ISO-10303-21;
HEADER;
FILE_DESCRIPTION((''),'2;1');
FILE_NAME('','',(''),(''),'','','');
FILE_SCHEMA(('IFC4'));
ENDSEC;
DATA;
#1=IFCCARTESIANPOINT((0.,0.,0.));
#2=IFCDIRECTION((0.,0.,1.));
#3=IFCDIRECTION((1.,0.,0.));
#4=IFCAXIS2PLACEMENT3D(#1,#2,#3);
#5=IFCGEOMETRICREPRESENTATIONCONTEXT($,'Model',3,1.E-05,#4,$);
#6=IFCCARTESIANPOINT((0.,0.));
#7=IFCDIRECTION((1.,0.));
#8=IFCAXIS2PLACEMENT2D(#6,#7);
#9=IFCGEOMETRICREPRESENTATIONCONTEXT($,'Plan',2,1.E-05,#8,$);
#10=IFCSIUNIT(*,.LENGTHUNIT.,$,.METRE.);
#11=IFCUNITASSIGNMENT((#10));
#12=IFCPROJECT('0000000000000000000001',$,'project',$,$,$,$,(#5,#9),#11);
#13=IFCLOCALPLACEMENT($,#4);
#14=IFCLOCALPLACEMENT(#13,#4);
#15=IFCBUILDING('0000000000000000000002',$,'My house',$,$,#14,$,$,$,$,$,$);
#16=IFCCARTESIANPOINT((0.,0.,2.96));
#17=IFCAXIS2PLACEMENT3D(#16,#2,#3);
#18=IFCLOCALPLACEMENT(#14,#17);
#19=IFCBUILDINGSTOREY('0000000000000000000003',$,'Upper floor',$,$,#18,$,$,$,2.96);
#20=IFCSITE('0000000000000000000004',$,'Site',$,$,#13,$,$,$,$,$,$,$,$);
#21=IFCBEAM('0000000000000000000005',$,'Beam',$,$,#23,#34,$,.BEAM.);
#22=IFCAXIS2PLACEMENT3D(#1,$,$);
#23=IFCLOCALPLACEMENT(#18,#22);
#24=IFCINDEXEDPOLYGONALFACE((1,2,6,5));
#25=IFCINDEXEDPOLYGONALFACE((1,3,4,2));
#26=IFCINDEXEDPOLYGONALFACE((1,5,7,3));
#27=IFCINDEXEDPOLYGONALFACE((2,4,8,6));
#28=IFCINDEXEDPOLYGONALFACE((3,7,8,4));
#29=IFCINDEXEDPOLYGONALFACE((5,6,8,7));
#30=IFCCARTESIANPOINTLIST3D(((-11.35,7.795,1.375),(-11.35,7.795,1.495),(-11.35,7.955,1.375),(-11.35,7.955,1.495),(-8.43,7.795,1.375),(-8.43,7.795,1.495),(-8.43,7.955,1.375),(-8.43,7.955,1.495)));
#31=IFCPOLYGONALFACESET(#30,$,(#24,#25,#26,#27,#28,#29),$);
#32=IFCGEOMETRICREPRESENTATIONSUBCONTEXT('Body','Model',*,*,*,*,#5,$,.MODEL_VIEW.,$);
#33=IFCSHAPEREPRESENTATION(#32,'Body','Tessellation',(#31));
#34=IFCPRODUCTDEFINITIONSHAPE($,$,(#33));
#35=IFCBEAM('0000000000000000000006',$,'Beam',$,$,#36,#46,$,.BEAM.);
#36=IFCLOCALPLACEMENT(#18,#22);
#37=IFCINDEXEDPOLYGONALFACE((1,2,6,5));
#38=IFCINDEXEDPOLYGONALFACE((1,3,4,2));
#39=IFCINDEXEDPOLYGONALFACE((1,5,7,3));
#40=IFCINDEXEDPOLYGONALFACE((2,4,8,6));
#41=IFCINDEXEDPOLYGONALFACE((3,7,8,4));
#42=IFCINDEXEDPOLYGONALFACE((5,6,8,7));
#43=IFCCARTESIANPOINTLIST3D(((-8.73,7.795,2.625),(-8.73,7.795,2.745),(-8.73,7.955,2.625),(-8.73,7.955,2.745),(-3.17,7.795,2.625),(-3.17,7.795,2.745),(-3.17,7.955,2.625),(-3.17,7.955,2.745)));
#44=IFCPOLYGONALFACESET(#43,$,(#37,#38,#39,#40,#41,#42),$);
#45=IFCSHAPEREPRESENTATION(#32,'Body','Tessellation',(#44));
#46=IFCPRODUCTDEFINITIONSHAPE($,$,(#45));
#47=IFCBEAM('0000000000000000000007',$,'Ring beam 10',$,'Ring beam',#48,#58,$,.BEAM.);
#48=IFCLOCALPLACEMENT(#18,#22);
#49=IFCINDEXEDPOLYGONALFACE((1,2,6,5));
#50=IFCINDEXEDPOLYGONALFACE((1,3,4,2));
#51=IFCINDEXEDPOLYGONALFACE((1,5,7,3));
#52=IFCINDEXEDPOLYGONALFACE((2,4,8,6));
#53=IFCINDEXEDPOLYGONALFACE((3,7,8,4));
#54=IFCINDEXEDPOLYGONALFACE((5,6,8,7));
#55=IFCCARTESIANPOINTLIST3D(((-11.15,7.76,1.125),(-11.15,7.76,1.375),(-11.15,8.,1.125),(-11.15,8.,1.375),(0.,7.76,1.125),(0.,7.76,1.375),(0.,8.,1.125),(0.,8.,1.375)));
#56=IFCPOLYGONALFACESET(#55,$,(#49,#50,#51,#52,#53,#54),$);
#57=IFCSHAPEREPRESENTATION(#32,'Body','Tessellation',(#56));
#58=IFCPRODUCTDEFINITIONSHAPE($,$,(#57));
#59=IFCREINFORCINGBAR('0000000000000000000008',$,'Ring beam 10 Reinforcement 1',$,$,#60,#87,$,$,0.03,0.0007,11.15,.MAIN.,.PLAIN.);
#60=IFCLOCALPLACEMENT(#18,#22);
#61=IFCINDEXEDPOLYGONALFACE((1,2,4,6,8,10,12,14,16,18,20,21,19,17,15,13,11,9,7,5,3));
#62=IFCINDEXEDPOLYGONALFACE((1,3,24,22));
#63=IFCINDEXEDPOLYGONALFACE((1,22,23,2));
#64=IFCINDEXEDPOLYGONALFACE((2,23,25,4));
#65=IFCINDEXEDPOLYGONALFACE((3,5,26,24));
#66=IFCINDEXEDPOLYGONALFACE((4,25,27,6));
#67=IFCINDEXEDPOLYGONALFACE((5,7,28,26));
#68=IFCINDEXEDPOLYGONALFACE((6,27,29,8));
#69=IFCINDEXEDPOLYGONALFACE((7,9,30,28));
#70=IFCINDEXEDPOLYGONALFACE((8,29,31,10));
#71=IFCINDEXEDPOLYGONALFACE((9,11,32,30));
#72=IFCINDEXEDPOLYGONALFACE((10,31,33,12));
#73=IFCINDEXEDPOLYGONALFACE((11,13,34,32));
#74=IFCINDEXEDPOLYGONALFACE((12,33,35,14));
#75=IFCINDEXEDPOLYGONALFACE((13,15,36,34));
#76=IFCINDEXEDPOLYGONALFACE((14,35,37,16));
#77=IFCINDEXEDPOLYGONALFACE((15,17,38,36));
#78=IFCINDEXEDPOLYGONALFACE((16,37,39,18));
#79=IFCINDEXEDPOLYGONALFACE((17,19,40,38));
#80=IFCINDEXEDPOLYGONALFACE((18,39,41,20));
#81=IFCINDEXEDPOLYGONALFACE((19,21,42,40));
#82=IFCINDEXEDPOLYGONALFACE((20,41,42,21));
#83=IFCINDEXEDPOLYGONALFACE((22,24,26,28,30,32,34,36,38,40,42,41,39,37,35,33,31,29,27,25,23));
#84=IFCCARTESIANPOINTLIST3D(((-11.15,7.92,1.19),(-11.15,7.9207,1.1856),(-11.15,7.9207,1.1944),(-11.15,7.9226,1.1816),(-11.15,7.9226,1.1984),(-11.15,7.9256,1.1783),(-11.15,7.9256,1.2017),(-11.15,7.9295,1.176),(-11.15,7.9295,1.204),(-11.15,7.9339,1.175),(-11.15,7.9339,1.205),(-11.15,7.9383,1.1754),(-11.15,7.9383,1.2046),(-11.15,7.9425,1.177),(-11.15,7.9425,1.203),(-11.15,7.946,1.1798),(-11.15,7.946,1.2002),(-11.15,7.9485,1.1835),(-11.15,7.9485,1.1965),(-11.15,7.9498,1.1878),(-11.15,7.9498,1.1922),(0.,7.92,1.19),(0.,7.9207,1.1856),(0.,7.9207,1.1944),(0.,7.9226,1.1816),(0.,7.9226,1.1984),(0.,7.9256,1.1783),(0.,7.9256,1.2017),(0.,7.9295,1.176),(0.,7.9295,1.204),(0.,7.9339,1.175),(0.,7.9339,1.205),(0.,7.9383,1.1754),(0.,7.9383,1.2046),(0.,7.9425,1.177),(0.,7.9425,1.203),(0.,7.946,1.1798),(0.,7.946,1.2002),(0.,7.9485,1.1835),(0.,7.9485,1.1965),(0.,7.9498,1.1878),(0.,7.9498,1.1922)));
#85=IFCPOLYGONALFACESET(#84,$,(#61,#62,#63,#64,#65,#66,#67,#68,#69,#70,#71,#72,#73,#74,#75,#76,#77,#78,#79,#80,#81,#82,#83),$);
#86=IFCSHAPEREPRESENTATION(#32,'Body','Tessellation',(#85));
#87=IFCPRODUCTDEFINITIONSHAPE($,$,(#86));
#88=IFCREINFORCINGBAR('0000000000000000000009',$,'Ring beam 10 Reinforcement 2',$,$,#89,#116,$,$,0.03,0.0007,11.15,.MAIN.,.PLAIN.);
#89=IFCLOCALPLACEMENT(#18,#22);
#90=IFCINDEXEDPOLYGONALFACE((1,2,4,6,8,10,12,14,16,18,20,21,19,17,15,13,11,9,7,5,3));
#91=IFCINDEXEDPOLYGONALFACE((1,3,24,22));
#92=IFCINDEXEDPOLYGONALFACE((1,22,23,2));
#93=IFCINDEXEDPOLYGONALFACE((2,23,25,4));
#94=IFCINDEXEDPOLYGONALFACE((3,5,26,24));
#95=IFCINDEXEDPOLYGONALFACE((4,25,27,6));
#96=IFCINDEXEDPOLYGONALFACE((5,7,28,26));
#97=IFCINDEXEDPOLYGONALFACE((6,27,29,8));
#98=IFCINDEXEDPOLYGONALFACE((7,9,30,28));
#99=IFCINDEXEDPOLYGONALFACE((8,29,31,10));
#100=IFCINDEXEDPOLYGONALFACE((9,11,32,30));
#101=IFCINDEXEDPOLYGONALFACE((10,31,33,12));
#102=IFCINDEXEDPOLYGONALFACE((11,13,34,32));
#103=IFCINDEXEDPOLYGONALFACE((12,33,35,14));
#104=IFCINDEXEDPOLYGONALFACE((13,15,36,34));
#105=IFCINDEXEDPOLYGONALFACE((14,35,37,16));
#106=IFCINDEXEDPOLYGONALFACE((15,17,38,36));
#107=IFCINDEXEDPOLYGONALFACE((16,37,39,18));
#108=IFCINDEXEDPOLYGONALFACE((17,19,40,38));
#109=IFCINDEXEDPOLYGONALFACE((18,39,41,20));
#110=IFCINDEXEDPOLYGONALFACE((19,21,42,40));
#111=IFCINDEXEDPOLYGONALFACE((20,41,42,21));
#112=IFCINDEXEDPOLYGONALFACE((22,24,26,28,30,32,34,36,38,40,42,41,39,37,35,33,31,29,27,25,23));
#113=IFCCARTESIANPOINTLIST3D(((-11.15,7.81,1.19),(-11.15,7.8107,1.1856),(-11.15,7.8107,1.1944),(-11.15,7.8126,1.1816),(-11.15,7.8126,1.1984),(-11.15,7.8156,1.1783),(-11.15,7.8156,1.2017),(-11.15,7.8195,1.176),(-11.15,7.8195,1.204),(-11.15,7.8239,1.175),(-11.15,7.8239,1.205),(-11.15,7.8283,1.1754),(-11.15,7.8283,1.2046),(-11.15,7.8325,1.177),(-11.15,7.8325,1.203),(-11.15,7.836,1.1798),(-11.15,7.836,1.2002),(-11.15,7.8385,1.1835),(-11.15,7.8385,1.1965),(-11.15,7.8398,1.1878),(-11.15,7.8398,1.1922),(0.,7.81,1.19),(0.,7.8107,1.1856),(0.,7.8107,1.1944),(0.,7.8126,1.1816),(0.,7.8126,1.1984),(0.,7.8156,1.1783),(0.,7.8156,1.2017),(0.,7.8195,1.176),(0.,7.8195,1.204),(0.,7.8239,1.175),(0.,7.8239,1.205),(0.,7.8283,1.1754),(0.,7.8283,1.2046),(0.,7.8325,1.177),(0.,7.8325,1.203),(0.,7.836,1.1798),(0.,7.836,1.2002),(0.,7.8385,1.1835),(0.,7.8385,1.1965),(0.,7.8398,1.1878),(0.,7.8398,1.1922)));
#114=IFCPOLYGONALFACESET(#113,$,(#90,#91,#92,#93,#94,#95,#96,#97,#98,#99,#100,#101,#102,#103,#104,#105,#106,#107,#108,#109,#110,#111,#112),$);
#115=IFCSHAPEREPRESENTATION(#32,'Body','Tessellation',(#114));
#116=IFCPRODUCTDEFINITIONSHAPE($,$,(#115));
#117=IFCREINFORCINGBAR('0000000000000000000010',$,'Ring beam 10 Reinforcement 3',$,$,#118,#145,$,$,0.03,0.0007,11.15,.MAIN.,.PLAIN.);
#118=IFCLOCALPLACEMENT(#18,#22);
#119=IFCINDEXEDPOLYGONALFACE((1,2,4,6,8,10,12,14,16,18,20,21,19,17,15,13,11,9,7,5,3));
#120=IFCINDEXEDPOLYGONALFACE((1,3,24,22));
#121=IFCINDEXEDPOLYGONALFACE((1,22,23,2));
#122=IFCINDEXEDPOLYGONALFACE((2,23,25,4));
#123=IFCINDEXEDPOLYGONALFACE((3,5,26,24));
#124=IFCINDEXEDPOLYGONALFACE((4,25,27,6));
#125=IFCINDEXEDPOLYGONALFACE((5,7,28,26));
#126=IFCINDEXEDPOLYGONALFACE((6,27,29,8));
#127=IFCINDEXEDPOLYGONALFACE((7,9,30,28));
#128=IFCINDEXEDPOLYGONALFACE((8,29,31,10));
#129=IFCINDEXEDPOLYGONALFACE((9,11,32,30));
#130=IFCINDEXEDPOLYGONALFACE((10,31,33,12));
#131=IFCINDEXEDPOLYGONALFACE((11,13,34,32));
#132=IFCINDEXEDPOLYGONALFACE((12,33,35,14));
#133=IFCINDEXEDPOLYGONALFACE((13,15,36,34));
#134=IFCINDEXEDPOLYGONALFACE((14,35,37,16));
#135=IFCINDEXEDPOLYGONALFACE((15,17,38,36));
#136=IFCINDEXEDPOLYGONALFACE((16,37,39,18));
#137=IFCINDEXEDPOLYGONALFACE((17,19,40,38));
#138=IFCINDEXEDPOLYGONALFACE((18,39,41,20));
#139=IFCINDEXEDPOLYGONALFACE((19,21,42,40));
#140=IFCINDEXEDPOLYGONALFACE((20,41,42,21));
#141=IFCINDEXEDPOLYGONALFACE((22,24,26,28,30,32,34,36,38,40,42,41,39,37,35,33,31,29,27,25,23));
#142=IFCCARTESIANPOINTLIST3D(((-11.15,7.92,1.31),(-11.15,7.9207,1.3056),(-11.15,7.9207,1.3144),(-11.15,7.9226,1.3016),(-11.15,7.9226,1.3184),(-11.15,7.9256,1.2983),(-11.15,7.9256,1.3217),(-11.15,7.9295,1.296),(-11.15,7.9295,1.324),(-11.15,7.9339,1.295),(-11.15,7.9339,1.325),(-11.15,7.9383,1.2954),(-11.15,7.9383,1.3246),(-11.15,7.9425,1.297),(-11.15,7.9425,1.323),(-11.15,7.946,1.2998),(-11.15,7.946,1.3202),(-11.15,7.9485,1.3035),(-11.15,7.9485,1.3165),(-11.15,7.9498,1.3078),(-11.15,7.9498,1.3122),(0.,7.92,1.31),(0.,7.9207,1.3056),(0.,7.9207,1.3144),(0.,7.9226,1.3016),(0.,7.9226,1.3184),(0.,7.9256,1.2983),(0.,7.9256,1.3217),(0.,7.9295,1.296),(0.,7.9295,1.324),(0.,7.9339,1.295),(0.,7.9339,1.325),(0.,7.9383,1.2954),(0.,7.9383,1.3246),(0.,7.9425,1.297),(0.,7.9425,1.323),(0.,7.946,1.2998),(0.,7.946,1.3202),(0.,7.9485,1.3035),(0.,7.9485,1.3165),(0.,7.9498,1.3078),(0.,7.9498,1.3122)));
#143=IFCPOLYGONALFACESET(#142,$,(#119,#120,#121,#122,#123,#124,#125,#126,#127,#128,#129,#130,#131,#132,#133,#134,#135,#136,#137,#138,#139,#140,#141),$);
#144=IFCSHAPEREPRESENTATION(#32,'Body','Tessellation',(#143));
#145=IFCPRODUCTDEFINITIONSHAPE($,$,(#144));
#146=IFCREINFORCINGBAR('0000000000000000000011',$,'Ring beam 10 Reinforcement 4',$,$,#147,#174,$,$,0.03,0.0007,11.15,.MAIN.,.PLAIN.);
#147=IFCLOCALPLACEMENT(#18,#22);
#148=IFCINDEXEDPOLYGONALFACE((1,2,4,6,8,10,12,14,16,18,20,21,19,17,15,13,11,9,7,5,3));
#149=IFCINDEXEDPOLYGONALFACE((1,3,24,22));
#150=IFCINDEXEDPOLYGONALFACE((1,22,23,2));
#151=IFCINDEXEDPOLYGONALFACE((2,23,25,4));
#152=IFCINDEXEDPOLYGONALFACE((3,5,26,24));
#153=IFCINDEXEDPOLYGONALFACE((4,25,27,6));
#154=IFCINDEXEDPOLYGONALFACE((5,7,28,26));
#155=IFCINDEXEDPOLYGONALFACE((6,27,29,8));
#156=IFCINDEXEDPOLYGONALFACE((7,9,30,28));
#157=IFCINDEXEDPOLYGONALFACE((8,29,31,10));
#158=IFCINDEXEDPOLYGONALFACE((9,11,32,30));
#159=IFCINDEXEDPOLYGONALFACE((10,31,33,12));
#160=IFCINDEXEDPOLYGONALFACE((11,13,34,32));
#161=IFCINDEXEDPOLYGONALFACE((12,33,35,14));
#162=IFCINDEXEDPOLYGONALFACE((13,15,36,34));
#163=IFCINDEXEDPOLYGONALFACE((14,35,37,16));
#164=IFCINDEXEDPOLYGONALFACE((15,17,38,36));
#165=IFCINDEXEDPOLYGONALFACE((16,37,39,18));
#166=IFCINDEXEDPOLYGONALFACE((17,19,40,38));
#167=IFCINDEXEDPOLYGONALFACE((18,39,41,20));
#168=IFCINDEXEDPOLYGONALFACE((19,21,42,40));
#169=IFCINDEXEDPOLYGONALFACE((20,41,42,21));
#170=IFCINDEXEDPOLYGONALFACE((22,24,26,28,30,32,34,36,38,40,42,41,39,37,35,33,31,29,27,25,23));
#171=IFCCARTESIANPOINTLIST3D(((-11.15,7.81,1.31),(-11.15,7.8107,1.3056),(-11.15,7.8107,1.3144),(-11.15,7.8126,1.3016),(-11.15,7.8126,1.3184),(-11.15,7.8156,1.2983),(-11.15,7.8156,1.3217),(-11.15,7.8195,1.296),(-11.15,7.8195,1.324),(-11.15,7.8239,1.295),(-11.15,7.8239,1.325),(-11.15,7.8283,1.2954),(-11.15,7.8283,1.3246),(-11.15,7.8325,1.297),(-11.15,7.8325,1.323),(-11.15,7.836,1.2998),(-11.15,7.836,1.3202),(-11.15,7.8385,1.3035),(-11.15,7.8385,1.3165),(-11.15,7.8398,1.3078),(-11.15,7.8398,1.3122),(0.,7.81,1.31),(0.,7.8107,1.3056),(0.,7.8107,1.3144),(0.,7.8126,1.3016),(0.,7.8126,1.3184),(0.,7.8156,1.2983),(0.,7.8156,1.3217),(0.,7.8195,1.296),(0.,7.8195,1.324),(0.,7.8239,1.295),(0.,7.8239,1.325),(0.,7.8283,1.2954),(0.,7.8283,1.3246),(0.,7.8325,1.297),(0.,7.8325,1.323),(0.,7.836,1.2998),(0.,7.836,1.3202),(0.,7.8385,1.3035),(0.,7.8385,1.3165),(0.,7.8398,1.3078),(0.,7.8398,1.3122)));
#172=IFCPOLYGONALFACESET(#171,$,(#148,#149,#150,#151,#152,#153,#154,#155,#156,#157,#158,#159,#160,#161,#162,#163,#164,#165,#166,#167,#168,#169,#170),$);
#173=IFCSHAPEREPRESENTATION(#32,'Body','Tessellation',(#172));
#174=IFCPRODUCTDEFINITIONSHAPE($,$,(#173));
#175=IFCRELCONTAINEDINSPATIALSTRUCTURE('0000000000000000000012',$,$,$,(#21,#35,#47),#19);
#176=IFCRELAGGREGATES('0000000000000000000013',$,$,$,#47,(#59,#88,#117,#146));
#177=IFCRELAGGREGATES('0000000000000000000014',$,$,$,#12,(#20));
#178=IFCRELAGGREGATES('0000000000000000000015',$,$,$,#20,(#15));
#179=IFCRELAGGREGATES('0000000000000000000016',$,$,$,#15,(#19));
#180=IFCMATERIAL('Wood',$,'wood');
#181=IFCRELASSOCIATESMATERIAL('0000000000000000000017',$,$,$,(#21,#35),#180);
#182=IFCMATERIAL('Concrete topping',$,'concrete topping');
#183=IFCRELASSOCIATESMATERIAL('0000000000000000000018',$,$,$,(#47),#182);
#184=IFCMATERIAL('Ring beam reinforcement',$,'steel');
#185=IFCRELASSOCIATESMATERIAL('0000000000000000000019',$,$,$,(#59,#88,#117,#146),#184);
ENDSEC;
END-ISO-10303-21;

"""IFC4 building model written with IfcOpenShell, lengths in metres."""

from ifc_helpers import new_model, si_unit, frame, origin_with_axes, origin_2d, origin_2d_with_axis, place, context, subcontext, project, spatial, circle_curve, rectangle, outline, extrude, source, transform, mapped, material, element, aggregate, save


model = new_model("IFC4")

# Units and contexts
model_context = context("Model", 3, precision=1e-05, world=origin_with_axes())
plan_context = context("Plan", 2, precision=1e-05, world=origin_2d_with_axis())
body_context_1 = subcontext(model_context, "Body", "Model", "MODEL_VIEW")
ifc_project = project(units=[si_unit("LENGTHUNIT", "METRE")], contexts=[model_context, plan_context])

# Site, building, storey
site_placement = place(None, origin_with_axes())
site = spatial("IfcSite", under=ifc_project, at=site_placement, Name="Site")
building_placement = place(site_placement, origin_with_axes())
building = spatial("IfcBuilding", under=site, at=building_placement, Name="My house")
storey_placement = place(building_placement, frame((0.0, 0.0, 2.96), z_axis=(0.0, 0.0, 1.0), x_axis=(1.0, 0.0, 0.0)))
storey = spatial("IfcBuildingStorey", under=building, at=storey_placement, Name="Upper floor", Elevation=2.96)

# Shared definitions
ifc_material_1 = material(Name="Concrete topping", Category="concrete topping")

# Beams
ifc_material_2 = material(Name="Wood", Category="wood")
shared_shape_1 = source(origin_with_axes(), body_context_1, "Body", "SweptSolid", [
    extrude(rectangle(XDim=0.16, YDim=0.12), frame((0.0, 0.0, 0.0), z_axis=(1.0, 0.0, 0.0), x_axis=(0.0, 1.0, 0.0)), (0.0, 0.0, 1.0), 2.92),
])
beam_1_placement = place(storey_placement, frame((-8.43, 7.875, 1.435), z_axis=(0.0, 0.0, 1.0), x_axis=(1.0, 0.0, 0.0)))
element("IfcBeam", 1, at=beam_1_placement, inside=storey, material=ifc_material_2, Name="Beam", PredefinedType="BEAM", context=body_context_1, shape_type="MappedRepresentation", body=[
    mapped(shared_shape_1, transform((0.0, 0.0, 0.0), x_axis=(-1.0, 0.0, 0.0), y_axis=(0.0, 1.0, 0.0), z_axis=(0.0, 0.0, 1.0), scale=1.0)),
])
shared_shape_2 = source(origin_with_axes(), body_context_1, "Body", "SweptSolid", [
    extrude(rectangle(XDim=0.16, YDim=0.12), frame((0.0, 0.0, 0.0), z_axis=(1.0, 0.0, 0.0), x_axis=(0.0, 1.0, 0.0)), (0.0, 0.0, 1.0), 5.56),
])
beam_2_placement = place(storey_placement, frame((-8.73, 7.875, 2.685), z_axis=(0.0, 0.0, 1.0), x_axis=(-1.0, 0.0, 0.0)))
element("IfcBeam", 2, at=beam_2_placement, inside=storey, material=ifc_material_2, Name="Beam", PredefinedType="BEAM", context=body_context_1, shape_type="MappedRepresentation", body=[
    mapped(shared_shape_2, transform((0.0, 0.0, 0.0), x_axis=(-1.0, 0.0, 0.0), y_axis=(0.0, 1.0, 0.0), z_axis=(0.0, 0.0, 1.0), scale=1.0)),
])

# Beam
shared_shape_3 = source(origin_with_axes(), body_context_1, "Body", "SweptSolid", [
    extrude(rectangle(XDim=0.24, YDim=0.25), frame((0.0, 0.0, 0.0), z_axis=(1.0, 0.0, 0.0), x_axis=(0.0, 1.0, 0.0)), (0.0, 0.0, 1.0), 11.15),
])
beam_3_placement = place(storey_placement, frame((-11.15, 7.88, 1.25), z_axis=(0.0, 0.0, 1.0), x_axis=(-1.0, 0.0, 0.0)))
beam_3 = element("IfcBeam", 3, at=beam_3_placement, inside=storey, material=ifc_material_1, Name="Ring beam 10", ObjectType="Ring beam", PredefinedType="BEAM", context=body_context_1, shape_type="MappedRepresentation", body=[
    mapped(shared_shape_3, transform((0.0, 0.0, 0.0), x_axis=(-1.0, 0.0, 0.0), y_axis=(0.0, 1.0, 0.0), z_axis=(0.0, 0.0, 1.0), scale=1.0)),
])

# Reinforcing bars
ifc_material_3 = material(Name="Ring beam reinforcement", Category="steel")
shared_shape_4 = source(origin_with_axes(), body_context_1, "Body", "SweptSolid", [
    extrude(outline(circle_curve(origin_2d(), 0.015)), frame((0.0, 0.0, 0.0), z_axis=(1.0, 0.0, 0.0), x_axis=(0.0, 1.0, 0.0)), (0.0, 0.0, 1.0), 11.15),
])
reinforcing_bar_1_placement = place(beam_3_placement, frame((0.0, -0.055, -0.06), z_axis=(0.0, 0.0, 1.0), x_axis=(1.0, 0.0, 0.0)))
reinforcing_bar_1 = element("IfcReinforcingBar", 4, at=reinforcing_bar_1_placement, material=ifc_material_3, Name="Ring beam 10 Reinforcement 1", BarLength=11.15, BarSurface="PLAIN", CrossSectionArea=0.0007, NominalDiameter=0.03, PredefinedType="MAIN", context=body_context_1, shape_type="MappedRepresentation", body=[
    mapped(shared_shape_4, transform((0.0, 0.0, 0.0), x_axis=(-1.0, 0.0, 0.0), y_axis=(0.0, 1.0, 0.0), z_axis=(0.0, 0.0, 1.0), scale=1.0)),
])
shared_shape_5 = source(origin_with_axes(), body_context_1, "Body", "SweptSolid", [
    extrude(outline(circle_curve(origin_2d(), 0.015)), frame((0.0, 0.0, 0.0), z_axis=(1.0, 0.0, 0.0), x_axis=(0.0, 1.0, 0.0)), (0.0, 0.0, 1.0), 11.15),
])
reinforcing_bar_2_placement = place(beam_3_placement, frame((0.0, 0.055, -0.06), z_axis=(0.0, 0.0, 1.0), x_axis=(1.0, 0.0, 0.0)))
reinforcing_bar_2 = element("IfcReinforcingBar", 5, at=reinforcing_bar_2_placement, material=ifc_material_3, Name="Ring beam 10 Reinforcement 2", BarLength=11.15, BarSurface="PLAIN", CrossSectionArea=0.0007, NominalDiameter=0.03, PredefinedType="MAIN", context=body_context_1, shape_type="MappedRepresentation", body=[
    mapped(shared_shape_5, transform((0.0, 0.0, 0.0), x_axis=(-1.0, 0.0, 0.0), y_axis=(0.0, 1.0, 0.0), z_axis=(0.0, 0.0, 1.0), scale=1.0)),
])
shared_shape_6 = source(origin_with_axes(), body_context_1, "Body", "SweptSolid", [
    extrude(outline(circle_curve(origin_2d(), 0.015)), frame((0.0, 0.0, 0.0), z_axis=(1.0, 0.0, 0.0), x_axis=(0.0, 1.0, 0.0)), (0.0, 0.0, 1.0), 11.15),
])
reinforcing_bar_3_placement = place(beam_3_placement, frame((0.0, -0.055, 0.06), z_axis=(0.0, 0.0, 1.0), x_axis=(1.0, 0.0, 0.0)))
reinforcing_bar_3 = element("IfcReinforcingBar", 6, at=reinforcing_bar_3_placement, material=ifc_material_3, Name="Ring beam 10 Reinforcement 3", BarLength=11.15, BarSurface="PLAIN", CrossSectionArea=0.0007, NominalDiameter=0.03, PredefinedType="MAIN", context=body_context_1, shape_type="MappedRepresentation", body=[
    mapped(shared_shape_6, transform((0.0, 0.0, 0.0), x_axis=(-1.0, 0.0, 0.0), y_axis=(0.0, 1.0, 0.0), z_axis=(0.0, 0.0, 1.0), scale=1.0)),
])
shared_shape_7 = source(origin_with_axes(), body_context_1, "Body", "SweptSolid", [
    extrude(outline(circle_curve(origin_2d(), 0.015)), frame((0.0, 0.0, 0.0), z_axis=(1.0, 0.0, 0.0), x_axis=(0.0, 1.0, 0.0)), (0.0, 0.0, 1.0), 11.15),
])
reinforcing_bar_4_placement = place(beam_3_placement, frame((0.0, 0.055, 0.06), z_axis=(0.0, 0.0, 1.0), x_axis=(1.0, 0.0, 0.0)))
reinforcing_bar_4 = element("IfcReinforcingBar", 7, at=reinforcing_bar_4_placement, material=ifc_material_3, Name="Ring beam 10 Reinforcement 4", BarLength=11.15, BarSurface="PLAIN", CrossSectionArea=0.0007, NominalDiameter=0.03, PredefinedType="MAIN", context=body_context_1, shape_type="MappedRepresentation", body=[
    mapped(shared_shape_7, transform((0.0, 0.0, 0.0), x_axis=(-1.0, 0.0, 0.0), y_axis=(0.0, 1.0, 0.0), z_axis=(0.0, 0.0, 1.0), scale=1.0)),
])
aggregate(beam_3, [reinforcing_bar_1, reinforcing_bar_2, reinforcing_bar_3, reinforcing_bar_4])

save(model, "model.ifc")
